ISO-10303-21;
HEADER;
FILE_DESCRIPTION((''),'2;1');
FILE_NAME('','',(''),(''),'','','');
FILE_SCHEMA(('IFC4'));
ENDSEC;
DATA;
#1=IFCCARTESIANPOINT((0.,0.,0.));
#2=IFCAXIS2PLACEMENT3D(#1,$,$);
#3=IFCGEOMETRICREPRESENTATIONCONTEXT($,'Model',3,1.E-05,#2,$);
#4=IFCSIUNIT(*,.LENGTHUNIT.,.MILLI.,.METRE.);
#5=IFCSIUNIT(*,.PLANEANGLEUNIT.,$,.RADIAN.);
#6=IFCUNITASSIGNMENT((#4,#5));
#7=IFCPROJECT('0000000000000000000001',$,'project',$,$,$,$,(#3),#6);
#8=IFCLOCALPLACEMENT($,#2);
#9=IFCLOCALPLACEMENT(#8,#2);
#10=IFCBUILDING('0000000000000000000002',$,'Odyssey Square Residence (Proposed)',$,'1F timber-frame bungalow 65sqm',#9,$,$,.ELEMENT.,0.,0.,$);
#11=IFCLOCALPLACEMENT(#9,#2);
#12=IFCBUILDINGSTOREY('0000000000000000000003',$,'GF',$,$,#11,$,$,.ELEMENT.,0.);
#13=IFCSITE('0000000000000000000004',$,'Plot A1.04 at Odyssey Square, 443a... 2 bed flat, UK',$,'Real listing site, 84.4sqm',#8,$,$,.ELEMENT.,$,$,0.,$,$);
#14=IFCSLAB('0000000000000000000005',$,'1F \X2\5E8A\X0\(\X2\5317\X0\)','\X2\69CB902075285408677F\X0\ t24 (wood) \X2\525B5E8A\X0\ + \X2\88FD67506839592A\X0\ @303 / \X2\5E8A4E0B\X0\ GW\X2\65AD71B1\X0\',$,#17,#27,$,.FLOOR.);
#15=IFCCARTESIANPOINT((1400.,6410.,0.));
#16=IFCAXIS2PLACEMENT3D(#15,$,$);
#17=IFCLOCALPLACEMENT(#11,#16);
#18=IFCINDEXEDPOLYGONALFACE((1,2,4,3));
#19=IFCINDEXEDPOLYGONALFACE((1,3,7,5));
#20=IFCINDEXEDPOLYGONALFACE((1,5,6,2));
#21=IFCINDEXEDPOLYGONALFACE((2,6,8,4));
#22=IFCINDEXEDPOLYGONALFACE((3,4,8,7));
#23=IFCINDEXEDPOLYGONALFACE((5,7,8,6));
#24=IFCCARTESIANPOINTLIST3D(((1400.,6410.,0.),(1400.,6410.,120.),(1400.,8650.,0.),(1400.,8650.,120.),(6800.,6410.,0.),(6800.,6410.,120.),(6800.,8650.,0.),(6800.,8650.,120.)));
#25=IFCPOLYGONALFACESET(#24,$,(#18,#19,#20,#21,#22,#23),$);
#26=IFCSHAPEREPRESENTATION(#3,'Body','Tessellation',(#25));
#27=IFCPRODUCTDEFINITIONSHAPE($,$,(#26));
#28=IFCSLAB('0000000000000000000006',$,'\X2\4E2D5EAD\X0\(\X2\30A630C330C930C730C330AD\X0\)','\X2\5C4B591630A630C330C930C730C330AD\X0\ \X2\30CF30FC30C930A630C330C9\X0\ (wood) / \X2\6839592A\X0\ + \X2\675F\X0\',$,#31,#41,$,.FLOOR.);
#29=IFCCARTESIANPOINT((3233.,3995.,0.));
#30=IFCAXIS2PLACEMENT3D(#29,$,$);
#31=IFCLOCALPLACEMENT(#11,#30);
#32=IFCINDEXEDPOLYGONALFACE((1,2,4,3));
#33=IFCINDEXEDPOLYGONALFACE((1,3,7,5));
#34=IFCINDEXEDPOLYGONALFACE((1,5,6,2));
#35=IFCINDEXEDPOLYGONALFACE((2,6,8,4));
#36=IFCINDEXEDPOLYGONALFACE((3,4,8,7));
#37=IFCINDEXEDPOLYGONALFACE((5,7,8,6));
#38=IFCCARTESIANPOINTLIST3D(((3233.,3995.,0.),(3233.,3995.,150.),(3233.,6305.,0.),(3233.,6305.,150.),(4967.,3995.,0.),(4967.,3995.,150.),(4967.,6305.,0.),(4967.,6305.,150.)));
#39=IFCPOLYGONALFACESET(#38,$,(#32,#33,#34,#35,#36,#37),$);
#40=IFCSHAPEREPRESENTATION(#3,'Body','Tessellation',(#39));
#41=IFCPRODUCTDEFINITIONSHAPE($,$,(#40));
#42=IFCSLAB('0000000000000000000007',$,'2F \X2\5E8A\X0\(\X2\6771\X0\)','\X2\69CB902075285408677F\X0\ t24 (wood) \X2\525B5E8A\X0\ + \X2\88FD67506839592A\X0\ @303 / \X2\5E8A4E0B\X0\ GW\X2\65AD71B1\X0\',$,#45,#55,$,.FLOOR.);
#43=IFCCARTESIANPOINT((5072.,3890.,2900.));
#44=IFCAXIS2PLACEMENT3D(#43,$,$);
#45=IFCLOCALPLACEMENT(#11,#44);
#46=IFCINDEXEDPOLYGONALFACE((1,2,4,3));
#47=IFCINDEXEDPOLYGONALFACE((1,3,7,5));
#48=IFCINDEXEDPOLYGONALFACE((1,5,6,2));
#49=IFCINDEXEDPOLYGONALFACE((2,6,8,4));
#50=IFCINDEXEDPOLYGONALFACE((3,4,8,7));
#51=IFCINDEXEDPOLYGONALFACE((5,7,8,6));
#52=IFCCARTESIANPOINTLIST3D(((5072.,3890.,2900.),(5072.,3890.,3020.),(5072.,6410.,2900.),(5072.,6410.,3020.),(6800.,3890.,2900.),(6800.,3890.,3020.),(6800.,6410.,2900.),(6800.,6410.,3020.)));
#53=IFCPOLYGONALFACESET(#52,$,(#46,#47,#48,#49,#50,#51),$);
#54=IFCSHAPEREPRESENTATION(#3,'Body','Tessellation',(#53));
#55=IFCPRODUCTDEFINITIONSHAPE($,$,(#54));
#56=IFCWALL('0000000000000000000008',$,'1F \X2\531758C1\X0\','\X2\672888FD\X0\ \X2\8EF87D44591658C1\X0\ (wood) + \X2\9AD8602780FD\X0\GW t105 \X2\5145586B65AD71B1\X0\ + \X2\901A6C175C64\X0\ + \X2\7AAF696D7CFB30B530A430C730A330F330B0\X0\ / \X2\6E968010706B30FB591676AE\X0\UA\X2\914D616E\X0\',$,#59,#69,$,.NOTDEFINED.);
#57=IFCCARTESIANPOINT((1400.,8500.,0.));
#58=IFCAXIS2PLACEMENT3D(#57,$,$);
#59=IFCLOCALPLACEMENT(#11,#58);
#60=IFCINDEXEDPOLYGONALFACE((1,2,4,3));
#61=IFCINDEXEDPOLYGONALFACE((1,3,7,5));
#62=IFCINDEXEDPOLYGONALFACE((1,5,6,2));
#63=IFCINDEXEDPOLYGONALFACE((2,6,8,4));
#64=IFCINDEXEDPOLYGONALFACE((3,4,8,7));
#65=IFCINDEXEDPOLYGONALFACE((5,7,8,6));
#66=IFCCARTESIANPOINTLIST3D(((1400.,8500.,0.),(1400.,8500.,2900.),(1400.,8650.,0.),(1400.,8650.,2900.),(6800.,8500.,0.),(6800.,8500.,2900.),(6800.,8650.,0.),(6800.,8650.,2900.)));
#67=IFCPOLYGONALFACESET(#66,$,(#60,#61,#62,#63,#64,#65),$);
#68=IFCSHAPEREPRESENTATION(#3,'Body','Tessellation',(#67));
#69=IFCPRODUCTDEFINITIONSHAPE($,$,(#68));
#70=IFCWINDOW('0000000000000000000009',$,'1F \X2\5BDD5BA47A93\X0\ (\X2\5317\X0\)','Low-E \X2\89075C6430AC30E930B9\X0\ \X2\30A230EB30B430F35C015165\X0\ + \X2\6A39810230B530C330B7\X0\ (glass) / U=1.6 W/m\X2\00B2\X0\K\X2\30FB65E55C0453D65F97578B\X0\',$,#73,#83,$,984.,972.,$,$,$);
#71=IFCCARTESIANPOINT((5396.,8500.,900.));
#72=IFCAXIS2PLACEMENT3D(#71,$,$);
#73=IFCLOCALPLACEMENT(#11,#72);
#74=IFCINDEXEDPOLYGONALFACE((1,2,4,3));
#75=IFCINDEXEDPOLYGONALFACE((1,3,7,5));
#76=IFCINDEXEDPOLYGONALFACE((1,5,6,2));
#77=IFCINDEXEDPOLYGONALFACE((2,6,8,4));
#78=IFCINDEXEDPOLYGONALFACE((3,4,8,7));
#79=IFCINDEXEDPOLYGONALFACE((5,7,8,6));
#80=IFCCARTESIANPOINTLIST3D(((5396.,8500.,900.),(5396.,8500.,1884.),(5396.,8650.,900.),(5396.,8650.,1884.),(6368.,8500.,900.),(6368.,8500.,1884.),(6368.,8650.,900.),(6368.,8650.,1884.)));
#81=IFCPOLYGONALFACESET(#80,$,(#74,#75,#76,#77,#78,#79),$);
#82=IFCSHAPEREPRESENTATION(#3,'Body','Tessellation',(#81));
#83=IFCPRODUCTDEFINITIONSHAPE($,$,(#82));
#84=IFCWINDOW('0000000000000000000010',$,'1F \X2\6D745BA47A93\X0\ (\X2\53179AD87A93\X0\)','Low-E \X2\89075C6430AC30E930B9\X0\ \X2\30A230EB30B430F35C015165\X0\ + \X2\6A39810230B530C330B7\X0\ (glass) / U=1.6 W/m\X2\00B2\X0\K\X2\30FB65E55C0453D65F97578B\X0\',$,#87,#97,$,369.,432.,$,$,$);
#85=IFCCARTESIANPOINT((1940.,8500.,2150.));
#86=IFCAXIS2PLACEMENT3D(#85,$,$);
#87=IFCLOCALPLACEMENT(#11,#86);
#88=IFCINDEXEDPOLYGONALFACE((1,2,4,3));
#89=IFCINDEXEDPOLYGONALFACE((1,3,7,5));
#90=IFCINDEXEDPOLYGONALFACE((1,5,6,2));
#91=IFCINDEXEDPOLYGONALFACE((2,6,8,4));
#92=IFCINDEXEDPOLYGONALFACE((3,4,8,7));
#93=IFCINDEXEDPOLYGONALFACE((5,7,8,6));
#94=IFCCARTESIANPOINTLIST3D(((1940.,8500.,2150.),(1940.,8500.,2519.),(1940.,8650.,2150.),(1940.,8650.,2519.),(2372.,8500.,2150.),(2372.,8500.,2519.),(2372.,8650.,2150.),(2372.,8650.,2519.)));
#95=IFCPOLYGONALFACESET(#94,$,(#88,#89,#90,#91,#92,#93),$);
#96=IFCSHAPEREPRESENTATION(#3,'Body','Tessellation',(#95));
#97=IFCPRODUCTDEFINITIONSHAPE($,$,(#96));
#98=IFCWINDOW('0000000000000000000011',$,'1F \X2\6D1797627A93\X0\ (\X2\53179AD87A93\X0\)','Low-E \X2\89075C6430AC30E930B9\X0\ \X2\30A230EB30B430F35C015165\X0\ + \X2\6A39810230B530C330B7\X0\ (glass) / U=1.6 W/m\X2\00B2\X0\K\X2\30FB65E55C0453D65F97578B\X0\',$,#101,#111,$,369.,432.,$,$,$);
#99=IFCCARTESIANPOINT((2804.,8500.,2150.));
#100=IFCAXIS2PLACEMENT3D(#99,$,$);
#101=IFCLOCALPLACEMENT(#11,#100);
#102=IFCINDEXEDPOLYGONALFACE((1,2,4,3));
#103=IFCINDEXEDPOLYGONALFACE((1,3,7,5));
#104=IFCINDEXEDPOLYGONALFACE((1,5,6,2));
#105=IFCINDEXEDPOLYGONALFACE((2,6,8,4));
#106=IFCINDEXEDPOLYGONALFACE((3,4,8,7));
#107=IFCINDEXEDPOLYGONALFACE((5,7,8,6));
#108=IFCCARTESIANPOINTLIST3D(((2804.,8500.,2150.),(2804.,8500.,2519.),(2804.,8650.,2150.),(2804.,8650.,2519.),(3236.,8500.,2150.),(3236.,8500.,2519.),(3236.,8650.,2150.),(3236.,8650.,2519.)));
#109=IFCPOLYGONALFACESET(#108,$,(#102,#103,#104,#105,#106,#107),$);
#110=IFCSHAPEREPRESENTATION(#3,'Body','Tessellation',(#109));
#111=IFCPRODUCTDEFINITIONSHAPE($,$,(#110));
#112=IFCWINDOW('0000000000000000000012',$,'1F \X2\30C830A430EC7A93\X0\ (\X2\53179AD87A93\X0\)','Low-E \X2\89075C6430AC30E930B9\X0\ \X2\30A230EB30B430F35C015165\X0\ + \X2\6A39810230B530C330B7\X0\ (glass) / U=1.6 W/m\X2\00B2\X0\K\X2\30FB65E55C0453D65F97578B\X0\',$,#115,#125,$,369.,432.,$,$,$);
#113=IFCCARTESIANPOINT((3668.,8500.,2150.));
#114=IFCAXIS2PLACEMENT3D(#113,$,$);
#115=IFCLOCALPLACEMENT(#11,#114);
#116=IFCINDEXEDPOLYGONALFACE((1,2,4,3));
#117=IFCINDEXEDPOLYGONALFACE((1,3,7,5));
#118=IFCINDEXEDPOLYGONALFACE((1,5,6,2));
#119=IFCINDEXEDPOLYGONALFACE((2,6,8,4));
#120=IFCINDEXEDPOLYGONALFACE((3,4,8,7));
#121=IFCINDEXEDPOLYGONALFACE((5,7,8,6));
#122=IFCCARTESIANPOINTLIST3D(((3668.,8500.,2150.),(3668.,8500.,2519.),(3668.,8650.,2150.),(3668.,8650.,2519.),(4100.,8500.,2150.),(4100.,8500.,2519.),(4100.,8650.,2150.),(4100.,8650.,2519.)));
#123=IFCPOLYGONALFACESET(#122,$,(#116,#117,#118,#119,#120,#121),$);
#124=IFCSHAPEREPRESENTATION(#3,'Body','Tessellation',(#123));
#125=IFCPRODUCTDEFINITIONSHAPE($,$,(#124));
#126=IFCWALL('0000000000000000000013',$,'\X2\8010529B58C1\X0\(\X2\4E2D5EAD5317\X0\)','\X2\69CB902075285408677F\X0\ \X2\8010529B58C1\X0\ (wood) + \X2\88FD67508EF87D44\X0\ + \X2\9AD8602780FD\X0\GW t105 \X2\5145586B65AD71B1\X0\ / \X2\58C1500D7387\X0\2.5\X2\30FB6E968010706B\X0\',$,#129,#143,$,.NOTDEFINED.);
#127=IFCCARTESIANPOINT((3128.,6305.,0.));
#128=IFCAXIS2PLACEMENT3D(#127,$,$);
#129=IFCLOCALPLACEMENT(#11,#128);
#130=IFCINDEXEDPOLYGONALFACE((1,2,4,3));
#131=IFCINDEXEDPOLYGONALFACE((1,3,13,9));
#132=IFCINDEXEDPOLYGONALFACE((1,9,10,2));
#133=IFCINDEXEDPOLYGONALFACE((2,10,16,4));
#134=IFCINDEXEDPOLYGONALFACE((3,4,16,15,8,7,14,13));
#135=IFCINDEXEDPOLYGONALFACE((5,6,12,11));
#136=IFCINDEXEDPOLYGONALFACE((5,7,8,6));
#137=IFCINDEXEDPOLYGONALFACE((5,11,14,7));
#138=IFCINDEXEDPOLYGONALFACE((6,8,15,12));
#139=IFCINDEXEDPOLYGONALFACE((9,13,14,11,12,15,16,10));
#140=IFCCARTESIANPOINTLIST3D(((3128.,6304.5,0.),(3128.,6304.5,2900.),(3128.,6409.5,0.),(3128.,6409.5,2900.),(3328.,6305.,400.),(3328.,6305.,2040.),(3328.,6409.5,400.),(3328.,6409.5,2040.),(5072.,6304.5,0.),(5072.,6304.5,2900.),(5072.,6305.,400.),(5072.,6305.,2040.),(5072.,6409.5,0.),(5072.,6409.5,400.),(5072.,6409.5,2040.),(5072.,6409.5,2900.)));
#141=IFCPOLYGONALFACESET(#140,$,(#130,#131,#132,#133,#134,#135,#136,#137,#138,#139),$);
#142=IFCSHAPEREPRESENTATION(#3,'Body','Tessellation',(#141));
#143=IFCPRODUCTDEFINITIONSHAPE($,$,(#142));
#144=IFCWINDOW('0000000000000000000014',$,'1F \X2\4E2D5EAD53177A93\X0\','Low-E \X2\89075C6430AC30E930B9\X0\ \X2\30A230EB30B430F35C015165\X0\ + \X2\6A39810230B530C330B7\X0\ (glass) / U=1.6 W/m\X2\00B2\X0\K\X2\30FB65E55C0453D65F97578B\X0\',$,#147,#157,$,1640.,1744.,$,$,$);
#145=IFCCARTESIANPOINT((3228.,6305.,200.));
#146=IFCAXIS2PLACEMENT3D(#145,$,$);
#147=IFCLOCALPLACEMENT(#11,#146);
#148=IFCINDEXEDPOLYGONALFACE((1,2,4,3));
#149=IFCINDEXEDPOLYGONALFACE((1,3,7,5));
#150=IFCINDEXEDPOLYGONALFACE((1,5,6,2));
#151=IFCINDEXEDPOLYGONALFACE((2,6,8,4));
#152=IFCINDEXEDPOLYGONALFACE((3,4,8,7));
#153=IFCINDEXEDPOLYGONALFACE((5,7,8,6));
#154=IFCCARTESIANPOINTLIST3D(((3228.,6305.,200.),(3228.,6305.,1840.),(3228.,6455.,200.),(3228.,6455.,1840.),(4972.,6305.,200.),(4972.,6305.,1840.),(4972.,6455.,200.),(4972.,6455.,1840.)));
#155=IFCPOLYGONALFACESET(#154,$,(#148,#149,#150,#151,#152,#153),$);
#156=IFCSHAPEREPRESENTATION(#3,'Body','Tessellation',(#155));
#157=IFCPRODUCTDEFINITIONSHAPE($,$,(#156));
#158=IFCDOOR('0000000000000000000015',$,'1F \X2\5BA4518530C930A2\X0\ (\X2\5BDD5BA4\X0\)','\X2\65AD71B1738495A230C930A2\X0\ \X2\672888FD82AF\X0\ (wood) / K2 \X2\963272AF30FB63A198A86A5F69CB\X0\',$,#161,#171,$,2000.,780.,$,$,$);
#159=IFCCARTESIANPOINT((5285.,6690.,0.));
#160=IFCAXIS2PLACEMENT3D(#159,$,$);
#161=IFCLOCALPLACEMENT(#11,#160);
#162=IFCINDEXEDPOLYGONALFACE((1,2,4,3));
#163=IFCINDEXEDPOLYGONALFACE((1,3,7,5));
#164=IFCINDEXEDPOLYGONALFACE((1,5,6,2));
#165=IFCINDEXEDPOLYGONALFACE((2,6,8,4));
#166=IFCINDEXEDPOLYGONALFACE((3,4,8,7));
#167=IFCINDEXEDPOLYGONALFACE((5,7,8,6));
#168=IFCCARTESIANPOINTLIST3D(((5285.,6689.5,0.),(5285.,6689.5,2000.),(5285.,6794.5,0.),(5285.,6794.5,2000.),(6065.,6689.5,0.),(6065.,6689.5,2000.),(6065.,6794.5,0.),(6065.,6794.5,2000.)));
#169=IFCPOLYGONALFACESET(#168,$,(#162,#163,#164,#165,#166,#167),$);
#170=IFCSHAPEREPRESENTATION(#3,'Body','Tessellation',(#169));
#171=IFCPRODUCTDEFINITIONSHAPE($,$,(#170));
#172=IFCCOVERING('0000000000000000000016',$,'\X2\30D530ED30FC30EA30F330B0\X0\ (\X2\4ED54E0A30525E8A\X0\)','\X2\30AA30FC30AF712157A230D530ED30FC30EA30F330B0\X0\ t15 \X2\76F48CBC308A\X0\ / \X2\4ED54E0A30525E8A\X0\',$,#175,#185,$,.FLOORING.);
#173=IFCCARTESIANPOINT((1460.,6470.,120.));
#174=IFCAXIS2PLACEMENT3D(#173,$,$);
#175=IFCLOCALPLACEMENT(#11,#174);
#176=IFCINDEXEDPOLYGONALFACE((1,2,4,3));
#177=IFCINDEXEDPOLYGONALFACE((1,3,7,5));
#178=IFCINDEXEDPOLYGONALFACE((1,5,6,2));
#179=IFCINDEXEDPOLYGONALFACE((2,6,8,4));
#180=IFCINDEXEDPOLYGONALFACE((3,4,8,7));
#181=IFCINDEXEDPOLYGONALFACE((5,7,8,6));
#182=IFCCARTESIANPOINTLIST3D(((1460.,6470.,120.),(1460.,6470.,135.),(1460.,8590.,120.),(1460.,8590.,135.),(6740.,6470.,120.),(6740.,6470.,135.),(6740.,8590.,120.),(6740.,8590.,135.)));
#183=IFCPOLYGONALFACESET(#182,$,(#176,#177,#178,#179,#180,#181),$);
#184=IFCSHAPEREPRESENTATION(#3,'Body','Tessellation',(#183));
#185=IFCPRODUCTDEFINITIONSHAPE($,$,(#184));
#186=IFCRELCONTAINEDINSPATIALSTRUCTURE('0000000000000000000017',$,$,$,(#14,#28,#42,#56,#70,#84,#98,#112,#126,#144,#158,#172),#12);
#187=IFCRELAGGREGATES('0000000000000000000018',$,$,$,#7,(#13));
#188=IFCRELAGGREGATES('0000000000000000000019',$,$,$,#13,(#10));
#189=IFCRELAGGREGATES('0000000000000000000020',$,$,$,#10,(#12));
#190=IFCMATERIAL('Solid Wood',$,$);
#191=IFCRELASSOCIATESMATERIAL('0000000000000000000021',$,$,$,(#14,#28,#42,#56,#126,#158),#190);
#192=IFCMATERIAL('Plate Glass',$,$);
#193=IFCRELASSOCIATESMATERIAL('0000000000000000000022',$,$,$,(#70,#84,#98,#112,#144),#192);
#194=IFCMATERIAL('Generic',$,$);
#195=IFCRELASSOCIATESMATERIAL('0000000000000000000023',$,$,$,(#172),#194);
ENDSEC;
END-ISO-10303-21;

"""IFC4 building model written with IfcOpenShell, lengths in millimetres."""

from ifc_helpers import new_model, si_unit, frame, frame_2d, origin, place, context, project, spatial, rectangle, extrude, material, element, fill, save


model = new_model("IFC4")

# Units and contexts
model_context = context("Model", 3, precision=1e-05, world=origin())
ifc_project = project(units=[si_unit("LENGTHUNIT", "METRE", prefix="MILLI"), si_unit("PLANEANGLEUNIT", "RADIAN")], contexts=[model_context])

# Site, building, storey
site_placement = place(None, origin())
site = spatial("IfcSite", under=ifc_project, at=site_placement, Name="Plot A1.04 at Odyssey Square, 443a... 2 bed flat, UK", ObjectType="Real listing site, 84.4sqm", CompositionType="ELEMENT", RefElevation=0.0)
building_placement = place(site_placement, origin())
building = spatial("IfcBuilding", under=site, at=building_placement, Name="Odyssey Square Residence (Proposed)", ObjectType="1F timber-frame bungalow 65sqm", CompositionType="ELEMENT", ElevationOfRefHeight=0.0, ElevationOfTerrain=0.0)
storey_placement = place(building_placement, origin())
storey = spatial("IfcBuildingStorey", under=building, at=storey_placement, Name="GF", CompositionType="ELEMENT", Elevation=0.0)

# Slabs
ifc_material_1 = material(Name="Solid Wood")
slab_1_placement = place(storey_placement, frame((1400.0, 6410.0, 0.0)))
element("IfcSlab", 1, at=slab_1_placement, inside=storey, material=ifc_material_1, Name="1F 床(北)", Description="構造用合板 t24 (wood) 剛床 + 製材根太 @303 / 床下 GW断熱", PredefinedType="FLOOR", context=model_context, shape_type="SweptSolid", body=[
    extrude(rectangle(XDim=5400.0, YDim=2240.0, at=frame_2d((2700.0, 1120.0))), frame((1400.0, 6410.0, 0.0)), (0.0, 0.0, 1.0), 120.0),
])
slab_2_placement = place(storey_placement, frame((3233.0, 3995.0, 0.0)))
element("IfcSlab", 2, at=slab_2_placement, inside=storey, material=ifc_material_1, Name="中庭(ウッドデッキ)", Description="屋外ウッドデッキ ハードウッド (wood) / 根太 + 束", PredefinedType="FLOOR", context=model_context, shape_type="SweptSolid", body=[
    extrude(rectangle(XDim=1734.0, YDim=2310.0, at=frame_2d((867.0, 1155.0))), frame((3233.0, 3995.0, 0.0)), (0.0, 0.0, 1.0), 150.0),
])
slab_3_placement = place(storey_placement, frame((5072.0, 3890.0, 2900.0)))
element("IfcSlab", 3, at=slab_3_placement, inside=storey, material=ifc_material_1, Name="2F 床(東)", Description="構造用合板 t24 (wood) 剛床 + 製材根太 @303 / 床下 GW断熱", PredefinedType="FLOOR", context=model_context, shape_type="SweptSolid", body=[
    extrude(rectangle(XDim=1728.0, YDim=2520.0, at=frame_2d((864.0, 1260.0))), frame((5072.0, 3890.0, 2900.0)), (0.0, 0.0, 1.0), 120.0),
])

# Wall, openings, windows
wall_1_placement = place(storey_placement, frame((1400.0, 8500.0, 0.0)))
wall_1 = element("IfcWall", 4, at=wall_1_placement, inside=storey, material=ifc_material_1, Name="1F 北壁", Description="木製 軸組外壁 (wood) + 高性能GW t105 充填断熱 + 通気層 + 窯業系サイディング / 準耐火・外皮UA配慮", PredefinedType="NOTDEFINED", context=model_context, shape_type="SweptSolid", body=[
    extrude(rectangle(XDim=5400.0, YDim=150.0, at=frame_2d((2700.0, 75.0))), frame((1400.0, 8500.0, 0.0)), (0.0, 0.0, 1.0), 2900.0),
])
opening_1_placement = place(storey_placement, frame((5396.0, 8500.0, 900.0)))
opening_1 = element("IfcOpeningElement", 5, at=opening_1_placement, cuts=wall_1, PredefinedType="NOTDEFINED", context=model_context, shape_type="SweptSolid", body=[
    extrude(rectangle(XDim=972.0, YDim=150.0, at=frame_2d((486.0, 75.0))), frame((5396.0, 8500.0, 900.0)), (0.0, 0.0, 1.0), 984.0),
])
opening_2_placement = place(storey_placement, frame((1940.0, 8500.0, 2150.0)))
opening_2 = element("IfcOpeningElement", 6, at=opening_2_placement, cuts=wall_1, PredefinedType="NOTDEFINED", context=model_context, shape_type="SweptSolid", body=[
    extrude(rectangle(XDim=432.0, YDim=150.0, at=frame_2d((216.0, 75.0))), frame((1940.0, 8500.0, 2150.0)), (0.0, 0.0, 1.0), 369.0),
])
opening_3_placement = place(storey_placement, frame((2804.0, 8500.0, 2150.0)))
opening_3 = element("IfcOpeningElement", 7, at=opening_3_placement, cuts=wall_1, PredefinedType="NOTDEFINED", context=model_context, shape_type="SweptSolid", body=[
    extrude(rectangle(XDim=432.0, YDim=150.0, at=frame_2d((216.0, 75.0))), frame((2804.0, 8500.0, 2150.0)), (0.0, 0.0, 1.0), 369.0),
])
opening_4_placement = place(storey_placement, frame((3668.0, 8500.0, 2150.0)))
opening_4 = element("IfcOpeningElement", 8, at=opening_4_placement, cuts=wall_1, PredefinedType="NOTDEFINED", context=model_context, shape_type="SweptSolid", body=[
    extrude(rectangle(XDim=432.0, YDim=150.0, at=frame_2d((216.0, 75.0))), frame((3668.0, 8500.0, 2150.0)), (0.0, 0.0, 1.0), 369.0),
])
ifc_material_2 = material(Name="Plate Glass")
window_1_placement = place(storey_placement, frame((5396.0, 8500.0, 900.0)))
window_1 = element("IfcWindow", 9, at=window_1_placement, inside=storey, material=ifc_material_2, Name="1F 寝室窓 (北)", Description="Low-E 複層ガラス アルゴン封入 + 樹脂サッシ (glass) / U=1.6 W/m²K・日射取得型", OverallHeight=984.0, OverallWidth=972.0, context=model_context, shape_type="SweptSolid", body=[
    extrude(rectangle(XDim=972.0, YDim=150.0, at=frame_2d((486.0, 75.0))), frame((5396.0, 8500.0, 900.0)), (0.0, 0.0, 1.0), 984.0),
])
fill(opening_1, window_1)
window_2_placement = place(storey_placement, frame((1940.0, 8500.0, 2150.0)))
window_2 = element("IfcWindow", 10, at=window_2_placement, inside=storey, material=ifc_material_2, Name="1F 浴室窓 (北高窓)", Description="Low-E 複層ガラス アルゴン封入 + 樹脂サッシ (glass) / U=1.6 W/m²K・日射取得型", OverallHeight=369.0, OverallWidth=432.0, context=model_context, shape_type="SweptSolid", body=[
    extrude(rectangle(XDim=432.0, YDim=150.0, at=frame_2d((216.0, 75.0))), frame((1940.0, 8500.0, 2150.0)), (0.0, 0.0, 1.0), 369.0),
])
fill(opening_2, window_2)
window_3_placement = place(storey_placement, frame((2804.0, 8500.0, 2150.0)))
window_3 = element("IfcWindow", 11, at=window_3_placement, inside=storey, material=ifc_material_2, Name="1F 洗面窓 (北高窓)", Description="Low-E 複層ガラス アルゴン封入 + 樹脂サッシ (glass) / U=1.6 W/m²K・日射取得型", OverallHeight=369.0, OverallWidth=432.0, context=model_context, shape_type="SweptSolid", body=[
    extrude(rectangle(XDim=432.0, YDim=150.0, at=frame_2d((216.0, 75.0))), frame((2804.0, 8500.0, 2150.0)), (0.0, 0.0, 1.0), 369.0),
])
fill(opening_3, window_3)
window_4_placement = place(storey_placement, frame((3668.0, 8500.0, 2150.0)))
window_4 = element("IfcWindow", 12, at=window_4_placement, inside=storey, material=ifc_material_2, Name="1F トイレ窓 (北高窓)", Description="Low-E 複層ガラス アルゴン封入 + 樹脂サッシ (glass) / U=1.6 W/m²K・日射取得型", OverallHeight=369.0, OverallWidth=432.0, context=model_context, shape_type="SweptSolid", body=[
    extrude(rectangle(XDim=432.0, YDim=150.0, at=frame_2d((216.0, 75.0))), frame((3668.0, 8500.0, 2150.0)), (0.0, 0.0, 1.0), 369.0),
])
fill(opening_4, window_4)

# Wall, opening, window
wall_2_placement = place(storey_placement, frame((3128.0, 6305.0, 0.0)))
wall_2 = element("IfcWall", 13, at=wall_2_placement, inside=storey, material=ifc_material_1, Name="耐力壁(中庭北)", Description="構造用合板 耐力壁 (wood) + 製材軸組 + 高性能GW t105 充填断熱 / 壁倍率2.5・準耐火", PredefinedType="NOTDEFINED", context=model_context, shape_type="SweptSolid", body=[
    extrude(rectangle(XDim=1944.0, YDim=105.0, at=frame_2d((972.0, 52.0))), frame((3128.0, 6305.0, 0.0)), (0.0, 0.0, 1.0), 2900.0),
])
opening_5_placement = place(storey_placement, frame((3228.0, 6305.0, 200.0)))
opening_5 = element("IfcOpeningElement", 14, at=opening_5_placement, cuts=wall_2, PredefinedType="NOTDEFINED", context=model_context, shape_type="SweptSolid", body=[
    extrude(rectangle(XDim=1744.0, YDim=150.0, at=frame_2d((872.0, 75.0))), frame((3228.0, 6305.0, 200.0)), (0.0, 0.0, 1.0), 1640.0),
])
window_5_placement = place(storey_placement, frame((3228.0, 6305.0, 200.0)))
window_5 = element("IfcWindow", 15, at=window_5_placement, inside=storey, material=ifc_material_2, Name="1F 中庭北窓", Description="Low-E 複層ガラス アルゴン封入 + 樹脂サッシ (glass) / U=1.6 W/m²K・日射取得型", OverallHeight=1640.0, OverallWidth=1744.0, context=model_context, shape_type="SweptSolid", body=[
    extrude(rectangle(XDim=1744.0, YDim=150.0, at=frame_2d((872.0, 75.0))), frame((3228.0, 6305.0, 200.0)), (0.0, 0.0, 1.0), 1640.0),
])
fill(opening_5, window_5)

# Door
door_1_placement = place(storey_placement, frame((5285.0, 6690.0, 0.0)))
element("IfcDoor", 16, at=door_1_placement, inside=storey, material=ifc_material_1, Name="1F 室内ドア (寝室)", Description="断熱玄関ドア 木製芯 (wood) / K2 防犯・採風機構", OverallHeight=2000.0, OverallWidth=780.0, context=model_context, shape_type="SweptSolid", body=[
    extrude(rectangle(XDim=780.0, YDim=105.0, at=frame_2d((390.0, 52.0))), frame((5285.0, 6690.0, 0.0)), (0.0, 0.0, 1.0), 2000.0),
])

# Covering
ifc_material_3 = material(Name="Generic")
covering_1_placement = place(storey_placement, frame((1460.0, 6470.0, 120.0)))
element("IfcCovering", 17, at=covering_1_placement, inside=storey, material=ifc_material_3, Name="フローリング (仕上げ床)", Description="オーク無垢フローリング t15 直貼り / 仕上げ床", PredefinedType="FLOORING", context=model_context, shape_type="SweptSolid", body=[
    extrude(rectangle(XDim=5280.0, YDim=2120.0, at=frame_2d((2640.0, 1060.0))), frame((1460.0, 6470.0, 120.0)), (0.0, 0.0, 1.0), 15.0),
])

save(model, "model.ifc")
